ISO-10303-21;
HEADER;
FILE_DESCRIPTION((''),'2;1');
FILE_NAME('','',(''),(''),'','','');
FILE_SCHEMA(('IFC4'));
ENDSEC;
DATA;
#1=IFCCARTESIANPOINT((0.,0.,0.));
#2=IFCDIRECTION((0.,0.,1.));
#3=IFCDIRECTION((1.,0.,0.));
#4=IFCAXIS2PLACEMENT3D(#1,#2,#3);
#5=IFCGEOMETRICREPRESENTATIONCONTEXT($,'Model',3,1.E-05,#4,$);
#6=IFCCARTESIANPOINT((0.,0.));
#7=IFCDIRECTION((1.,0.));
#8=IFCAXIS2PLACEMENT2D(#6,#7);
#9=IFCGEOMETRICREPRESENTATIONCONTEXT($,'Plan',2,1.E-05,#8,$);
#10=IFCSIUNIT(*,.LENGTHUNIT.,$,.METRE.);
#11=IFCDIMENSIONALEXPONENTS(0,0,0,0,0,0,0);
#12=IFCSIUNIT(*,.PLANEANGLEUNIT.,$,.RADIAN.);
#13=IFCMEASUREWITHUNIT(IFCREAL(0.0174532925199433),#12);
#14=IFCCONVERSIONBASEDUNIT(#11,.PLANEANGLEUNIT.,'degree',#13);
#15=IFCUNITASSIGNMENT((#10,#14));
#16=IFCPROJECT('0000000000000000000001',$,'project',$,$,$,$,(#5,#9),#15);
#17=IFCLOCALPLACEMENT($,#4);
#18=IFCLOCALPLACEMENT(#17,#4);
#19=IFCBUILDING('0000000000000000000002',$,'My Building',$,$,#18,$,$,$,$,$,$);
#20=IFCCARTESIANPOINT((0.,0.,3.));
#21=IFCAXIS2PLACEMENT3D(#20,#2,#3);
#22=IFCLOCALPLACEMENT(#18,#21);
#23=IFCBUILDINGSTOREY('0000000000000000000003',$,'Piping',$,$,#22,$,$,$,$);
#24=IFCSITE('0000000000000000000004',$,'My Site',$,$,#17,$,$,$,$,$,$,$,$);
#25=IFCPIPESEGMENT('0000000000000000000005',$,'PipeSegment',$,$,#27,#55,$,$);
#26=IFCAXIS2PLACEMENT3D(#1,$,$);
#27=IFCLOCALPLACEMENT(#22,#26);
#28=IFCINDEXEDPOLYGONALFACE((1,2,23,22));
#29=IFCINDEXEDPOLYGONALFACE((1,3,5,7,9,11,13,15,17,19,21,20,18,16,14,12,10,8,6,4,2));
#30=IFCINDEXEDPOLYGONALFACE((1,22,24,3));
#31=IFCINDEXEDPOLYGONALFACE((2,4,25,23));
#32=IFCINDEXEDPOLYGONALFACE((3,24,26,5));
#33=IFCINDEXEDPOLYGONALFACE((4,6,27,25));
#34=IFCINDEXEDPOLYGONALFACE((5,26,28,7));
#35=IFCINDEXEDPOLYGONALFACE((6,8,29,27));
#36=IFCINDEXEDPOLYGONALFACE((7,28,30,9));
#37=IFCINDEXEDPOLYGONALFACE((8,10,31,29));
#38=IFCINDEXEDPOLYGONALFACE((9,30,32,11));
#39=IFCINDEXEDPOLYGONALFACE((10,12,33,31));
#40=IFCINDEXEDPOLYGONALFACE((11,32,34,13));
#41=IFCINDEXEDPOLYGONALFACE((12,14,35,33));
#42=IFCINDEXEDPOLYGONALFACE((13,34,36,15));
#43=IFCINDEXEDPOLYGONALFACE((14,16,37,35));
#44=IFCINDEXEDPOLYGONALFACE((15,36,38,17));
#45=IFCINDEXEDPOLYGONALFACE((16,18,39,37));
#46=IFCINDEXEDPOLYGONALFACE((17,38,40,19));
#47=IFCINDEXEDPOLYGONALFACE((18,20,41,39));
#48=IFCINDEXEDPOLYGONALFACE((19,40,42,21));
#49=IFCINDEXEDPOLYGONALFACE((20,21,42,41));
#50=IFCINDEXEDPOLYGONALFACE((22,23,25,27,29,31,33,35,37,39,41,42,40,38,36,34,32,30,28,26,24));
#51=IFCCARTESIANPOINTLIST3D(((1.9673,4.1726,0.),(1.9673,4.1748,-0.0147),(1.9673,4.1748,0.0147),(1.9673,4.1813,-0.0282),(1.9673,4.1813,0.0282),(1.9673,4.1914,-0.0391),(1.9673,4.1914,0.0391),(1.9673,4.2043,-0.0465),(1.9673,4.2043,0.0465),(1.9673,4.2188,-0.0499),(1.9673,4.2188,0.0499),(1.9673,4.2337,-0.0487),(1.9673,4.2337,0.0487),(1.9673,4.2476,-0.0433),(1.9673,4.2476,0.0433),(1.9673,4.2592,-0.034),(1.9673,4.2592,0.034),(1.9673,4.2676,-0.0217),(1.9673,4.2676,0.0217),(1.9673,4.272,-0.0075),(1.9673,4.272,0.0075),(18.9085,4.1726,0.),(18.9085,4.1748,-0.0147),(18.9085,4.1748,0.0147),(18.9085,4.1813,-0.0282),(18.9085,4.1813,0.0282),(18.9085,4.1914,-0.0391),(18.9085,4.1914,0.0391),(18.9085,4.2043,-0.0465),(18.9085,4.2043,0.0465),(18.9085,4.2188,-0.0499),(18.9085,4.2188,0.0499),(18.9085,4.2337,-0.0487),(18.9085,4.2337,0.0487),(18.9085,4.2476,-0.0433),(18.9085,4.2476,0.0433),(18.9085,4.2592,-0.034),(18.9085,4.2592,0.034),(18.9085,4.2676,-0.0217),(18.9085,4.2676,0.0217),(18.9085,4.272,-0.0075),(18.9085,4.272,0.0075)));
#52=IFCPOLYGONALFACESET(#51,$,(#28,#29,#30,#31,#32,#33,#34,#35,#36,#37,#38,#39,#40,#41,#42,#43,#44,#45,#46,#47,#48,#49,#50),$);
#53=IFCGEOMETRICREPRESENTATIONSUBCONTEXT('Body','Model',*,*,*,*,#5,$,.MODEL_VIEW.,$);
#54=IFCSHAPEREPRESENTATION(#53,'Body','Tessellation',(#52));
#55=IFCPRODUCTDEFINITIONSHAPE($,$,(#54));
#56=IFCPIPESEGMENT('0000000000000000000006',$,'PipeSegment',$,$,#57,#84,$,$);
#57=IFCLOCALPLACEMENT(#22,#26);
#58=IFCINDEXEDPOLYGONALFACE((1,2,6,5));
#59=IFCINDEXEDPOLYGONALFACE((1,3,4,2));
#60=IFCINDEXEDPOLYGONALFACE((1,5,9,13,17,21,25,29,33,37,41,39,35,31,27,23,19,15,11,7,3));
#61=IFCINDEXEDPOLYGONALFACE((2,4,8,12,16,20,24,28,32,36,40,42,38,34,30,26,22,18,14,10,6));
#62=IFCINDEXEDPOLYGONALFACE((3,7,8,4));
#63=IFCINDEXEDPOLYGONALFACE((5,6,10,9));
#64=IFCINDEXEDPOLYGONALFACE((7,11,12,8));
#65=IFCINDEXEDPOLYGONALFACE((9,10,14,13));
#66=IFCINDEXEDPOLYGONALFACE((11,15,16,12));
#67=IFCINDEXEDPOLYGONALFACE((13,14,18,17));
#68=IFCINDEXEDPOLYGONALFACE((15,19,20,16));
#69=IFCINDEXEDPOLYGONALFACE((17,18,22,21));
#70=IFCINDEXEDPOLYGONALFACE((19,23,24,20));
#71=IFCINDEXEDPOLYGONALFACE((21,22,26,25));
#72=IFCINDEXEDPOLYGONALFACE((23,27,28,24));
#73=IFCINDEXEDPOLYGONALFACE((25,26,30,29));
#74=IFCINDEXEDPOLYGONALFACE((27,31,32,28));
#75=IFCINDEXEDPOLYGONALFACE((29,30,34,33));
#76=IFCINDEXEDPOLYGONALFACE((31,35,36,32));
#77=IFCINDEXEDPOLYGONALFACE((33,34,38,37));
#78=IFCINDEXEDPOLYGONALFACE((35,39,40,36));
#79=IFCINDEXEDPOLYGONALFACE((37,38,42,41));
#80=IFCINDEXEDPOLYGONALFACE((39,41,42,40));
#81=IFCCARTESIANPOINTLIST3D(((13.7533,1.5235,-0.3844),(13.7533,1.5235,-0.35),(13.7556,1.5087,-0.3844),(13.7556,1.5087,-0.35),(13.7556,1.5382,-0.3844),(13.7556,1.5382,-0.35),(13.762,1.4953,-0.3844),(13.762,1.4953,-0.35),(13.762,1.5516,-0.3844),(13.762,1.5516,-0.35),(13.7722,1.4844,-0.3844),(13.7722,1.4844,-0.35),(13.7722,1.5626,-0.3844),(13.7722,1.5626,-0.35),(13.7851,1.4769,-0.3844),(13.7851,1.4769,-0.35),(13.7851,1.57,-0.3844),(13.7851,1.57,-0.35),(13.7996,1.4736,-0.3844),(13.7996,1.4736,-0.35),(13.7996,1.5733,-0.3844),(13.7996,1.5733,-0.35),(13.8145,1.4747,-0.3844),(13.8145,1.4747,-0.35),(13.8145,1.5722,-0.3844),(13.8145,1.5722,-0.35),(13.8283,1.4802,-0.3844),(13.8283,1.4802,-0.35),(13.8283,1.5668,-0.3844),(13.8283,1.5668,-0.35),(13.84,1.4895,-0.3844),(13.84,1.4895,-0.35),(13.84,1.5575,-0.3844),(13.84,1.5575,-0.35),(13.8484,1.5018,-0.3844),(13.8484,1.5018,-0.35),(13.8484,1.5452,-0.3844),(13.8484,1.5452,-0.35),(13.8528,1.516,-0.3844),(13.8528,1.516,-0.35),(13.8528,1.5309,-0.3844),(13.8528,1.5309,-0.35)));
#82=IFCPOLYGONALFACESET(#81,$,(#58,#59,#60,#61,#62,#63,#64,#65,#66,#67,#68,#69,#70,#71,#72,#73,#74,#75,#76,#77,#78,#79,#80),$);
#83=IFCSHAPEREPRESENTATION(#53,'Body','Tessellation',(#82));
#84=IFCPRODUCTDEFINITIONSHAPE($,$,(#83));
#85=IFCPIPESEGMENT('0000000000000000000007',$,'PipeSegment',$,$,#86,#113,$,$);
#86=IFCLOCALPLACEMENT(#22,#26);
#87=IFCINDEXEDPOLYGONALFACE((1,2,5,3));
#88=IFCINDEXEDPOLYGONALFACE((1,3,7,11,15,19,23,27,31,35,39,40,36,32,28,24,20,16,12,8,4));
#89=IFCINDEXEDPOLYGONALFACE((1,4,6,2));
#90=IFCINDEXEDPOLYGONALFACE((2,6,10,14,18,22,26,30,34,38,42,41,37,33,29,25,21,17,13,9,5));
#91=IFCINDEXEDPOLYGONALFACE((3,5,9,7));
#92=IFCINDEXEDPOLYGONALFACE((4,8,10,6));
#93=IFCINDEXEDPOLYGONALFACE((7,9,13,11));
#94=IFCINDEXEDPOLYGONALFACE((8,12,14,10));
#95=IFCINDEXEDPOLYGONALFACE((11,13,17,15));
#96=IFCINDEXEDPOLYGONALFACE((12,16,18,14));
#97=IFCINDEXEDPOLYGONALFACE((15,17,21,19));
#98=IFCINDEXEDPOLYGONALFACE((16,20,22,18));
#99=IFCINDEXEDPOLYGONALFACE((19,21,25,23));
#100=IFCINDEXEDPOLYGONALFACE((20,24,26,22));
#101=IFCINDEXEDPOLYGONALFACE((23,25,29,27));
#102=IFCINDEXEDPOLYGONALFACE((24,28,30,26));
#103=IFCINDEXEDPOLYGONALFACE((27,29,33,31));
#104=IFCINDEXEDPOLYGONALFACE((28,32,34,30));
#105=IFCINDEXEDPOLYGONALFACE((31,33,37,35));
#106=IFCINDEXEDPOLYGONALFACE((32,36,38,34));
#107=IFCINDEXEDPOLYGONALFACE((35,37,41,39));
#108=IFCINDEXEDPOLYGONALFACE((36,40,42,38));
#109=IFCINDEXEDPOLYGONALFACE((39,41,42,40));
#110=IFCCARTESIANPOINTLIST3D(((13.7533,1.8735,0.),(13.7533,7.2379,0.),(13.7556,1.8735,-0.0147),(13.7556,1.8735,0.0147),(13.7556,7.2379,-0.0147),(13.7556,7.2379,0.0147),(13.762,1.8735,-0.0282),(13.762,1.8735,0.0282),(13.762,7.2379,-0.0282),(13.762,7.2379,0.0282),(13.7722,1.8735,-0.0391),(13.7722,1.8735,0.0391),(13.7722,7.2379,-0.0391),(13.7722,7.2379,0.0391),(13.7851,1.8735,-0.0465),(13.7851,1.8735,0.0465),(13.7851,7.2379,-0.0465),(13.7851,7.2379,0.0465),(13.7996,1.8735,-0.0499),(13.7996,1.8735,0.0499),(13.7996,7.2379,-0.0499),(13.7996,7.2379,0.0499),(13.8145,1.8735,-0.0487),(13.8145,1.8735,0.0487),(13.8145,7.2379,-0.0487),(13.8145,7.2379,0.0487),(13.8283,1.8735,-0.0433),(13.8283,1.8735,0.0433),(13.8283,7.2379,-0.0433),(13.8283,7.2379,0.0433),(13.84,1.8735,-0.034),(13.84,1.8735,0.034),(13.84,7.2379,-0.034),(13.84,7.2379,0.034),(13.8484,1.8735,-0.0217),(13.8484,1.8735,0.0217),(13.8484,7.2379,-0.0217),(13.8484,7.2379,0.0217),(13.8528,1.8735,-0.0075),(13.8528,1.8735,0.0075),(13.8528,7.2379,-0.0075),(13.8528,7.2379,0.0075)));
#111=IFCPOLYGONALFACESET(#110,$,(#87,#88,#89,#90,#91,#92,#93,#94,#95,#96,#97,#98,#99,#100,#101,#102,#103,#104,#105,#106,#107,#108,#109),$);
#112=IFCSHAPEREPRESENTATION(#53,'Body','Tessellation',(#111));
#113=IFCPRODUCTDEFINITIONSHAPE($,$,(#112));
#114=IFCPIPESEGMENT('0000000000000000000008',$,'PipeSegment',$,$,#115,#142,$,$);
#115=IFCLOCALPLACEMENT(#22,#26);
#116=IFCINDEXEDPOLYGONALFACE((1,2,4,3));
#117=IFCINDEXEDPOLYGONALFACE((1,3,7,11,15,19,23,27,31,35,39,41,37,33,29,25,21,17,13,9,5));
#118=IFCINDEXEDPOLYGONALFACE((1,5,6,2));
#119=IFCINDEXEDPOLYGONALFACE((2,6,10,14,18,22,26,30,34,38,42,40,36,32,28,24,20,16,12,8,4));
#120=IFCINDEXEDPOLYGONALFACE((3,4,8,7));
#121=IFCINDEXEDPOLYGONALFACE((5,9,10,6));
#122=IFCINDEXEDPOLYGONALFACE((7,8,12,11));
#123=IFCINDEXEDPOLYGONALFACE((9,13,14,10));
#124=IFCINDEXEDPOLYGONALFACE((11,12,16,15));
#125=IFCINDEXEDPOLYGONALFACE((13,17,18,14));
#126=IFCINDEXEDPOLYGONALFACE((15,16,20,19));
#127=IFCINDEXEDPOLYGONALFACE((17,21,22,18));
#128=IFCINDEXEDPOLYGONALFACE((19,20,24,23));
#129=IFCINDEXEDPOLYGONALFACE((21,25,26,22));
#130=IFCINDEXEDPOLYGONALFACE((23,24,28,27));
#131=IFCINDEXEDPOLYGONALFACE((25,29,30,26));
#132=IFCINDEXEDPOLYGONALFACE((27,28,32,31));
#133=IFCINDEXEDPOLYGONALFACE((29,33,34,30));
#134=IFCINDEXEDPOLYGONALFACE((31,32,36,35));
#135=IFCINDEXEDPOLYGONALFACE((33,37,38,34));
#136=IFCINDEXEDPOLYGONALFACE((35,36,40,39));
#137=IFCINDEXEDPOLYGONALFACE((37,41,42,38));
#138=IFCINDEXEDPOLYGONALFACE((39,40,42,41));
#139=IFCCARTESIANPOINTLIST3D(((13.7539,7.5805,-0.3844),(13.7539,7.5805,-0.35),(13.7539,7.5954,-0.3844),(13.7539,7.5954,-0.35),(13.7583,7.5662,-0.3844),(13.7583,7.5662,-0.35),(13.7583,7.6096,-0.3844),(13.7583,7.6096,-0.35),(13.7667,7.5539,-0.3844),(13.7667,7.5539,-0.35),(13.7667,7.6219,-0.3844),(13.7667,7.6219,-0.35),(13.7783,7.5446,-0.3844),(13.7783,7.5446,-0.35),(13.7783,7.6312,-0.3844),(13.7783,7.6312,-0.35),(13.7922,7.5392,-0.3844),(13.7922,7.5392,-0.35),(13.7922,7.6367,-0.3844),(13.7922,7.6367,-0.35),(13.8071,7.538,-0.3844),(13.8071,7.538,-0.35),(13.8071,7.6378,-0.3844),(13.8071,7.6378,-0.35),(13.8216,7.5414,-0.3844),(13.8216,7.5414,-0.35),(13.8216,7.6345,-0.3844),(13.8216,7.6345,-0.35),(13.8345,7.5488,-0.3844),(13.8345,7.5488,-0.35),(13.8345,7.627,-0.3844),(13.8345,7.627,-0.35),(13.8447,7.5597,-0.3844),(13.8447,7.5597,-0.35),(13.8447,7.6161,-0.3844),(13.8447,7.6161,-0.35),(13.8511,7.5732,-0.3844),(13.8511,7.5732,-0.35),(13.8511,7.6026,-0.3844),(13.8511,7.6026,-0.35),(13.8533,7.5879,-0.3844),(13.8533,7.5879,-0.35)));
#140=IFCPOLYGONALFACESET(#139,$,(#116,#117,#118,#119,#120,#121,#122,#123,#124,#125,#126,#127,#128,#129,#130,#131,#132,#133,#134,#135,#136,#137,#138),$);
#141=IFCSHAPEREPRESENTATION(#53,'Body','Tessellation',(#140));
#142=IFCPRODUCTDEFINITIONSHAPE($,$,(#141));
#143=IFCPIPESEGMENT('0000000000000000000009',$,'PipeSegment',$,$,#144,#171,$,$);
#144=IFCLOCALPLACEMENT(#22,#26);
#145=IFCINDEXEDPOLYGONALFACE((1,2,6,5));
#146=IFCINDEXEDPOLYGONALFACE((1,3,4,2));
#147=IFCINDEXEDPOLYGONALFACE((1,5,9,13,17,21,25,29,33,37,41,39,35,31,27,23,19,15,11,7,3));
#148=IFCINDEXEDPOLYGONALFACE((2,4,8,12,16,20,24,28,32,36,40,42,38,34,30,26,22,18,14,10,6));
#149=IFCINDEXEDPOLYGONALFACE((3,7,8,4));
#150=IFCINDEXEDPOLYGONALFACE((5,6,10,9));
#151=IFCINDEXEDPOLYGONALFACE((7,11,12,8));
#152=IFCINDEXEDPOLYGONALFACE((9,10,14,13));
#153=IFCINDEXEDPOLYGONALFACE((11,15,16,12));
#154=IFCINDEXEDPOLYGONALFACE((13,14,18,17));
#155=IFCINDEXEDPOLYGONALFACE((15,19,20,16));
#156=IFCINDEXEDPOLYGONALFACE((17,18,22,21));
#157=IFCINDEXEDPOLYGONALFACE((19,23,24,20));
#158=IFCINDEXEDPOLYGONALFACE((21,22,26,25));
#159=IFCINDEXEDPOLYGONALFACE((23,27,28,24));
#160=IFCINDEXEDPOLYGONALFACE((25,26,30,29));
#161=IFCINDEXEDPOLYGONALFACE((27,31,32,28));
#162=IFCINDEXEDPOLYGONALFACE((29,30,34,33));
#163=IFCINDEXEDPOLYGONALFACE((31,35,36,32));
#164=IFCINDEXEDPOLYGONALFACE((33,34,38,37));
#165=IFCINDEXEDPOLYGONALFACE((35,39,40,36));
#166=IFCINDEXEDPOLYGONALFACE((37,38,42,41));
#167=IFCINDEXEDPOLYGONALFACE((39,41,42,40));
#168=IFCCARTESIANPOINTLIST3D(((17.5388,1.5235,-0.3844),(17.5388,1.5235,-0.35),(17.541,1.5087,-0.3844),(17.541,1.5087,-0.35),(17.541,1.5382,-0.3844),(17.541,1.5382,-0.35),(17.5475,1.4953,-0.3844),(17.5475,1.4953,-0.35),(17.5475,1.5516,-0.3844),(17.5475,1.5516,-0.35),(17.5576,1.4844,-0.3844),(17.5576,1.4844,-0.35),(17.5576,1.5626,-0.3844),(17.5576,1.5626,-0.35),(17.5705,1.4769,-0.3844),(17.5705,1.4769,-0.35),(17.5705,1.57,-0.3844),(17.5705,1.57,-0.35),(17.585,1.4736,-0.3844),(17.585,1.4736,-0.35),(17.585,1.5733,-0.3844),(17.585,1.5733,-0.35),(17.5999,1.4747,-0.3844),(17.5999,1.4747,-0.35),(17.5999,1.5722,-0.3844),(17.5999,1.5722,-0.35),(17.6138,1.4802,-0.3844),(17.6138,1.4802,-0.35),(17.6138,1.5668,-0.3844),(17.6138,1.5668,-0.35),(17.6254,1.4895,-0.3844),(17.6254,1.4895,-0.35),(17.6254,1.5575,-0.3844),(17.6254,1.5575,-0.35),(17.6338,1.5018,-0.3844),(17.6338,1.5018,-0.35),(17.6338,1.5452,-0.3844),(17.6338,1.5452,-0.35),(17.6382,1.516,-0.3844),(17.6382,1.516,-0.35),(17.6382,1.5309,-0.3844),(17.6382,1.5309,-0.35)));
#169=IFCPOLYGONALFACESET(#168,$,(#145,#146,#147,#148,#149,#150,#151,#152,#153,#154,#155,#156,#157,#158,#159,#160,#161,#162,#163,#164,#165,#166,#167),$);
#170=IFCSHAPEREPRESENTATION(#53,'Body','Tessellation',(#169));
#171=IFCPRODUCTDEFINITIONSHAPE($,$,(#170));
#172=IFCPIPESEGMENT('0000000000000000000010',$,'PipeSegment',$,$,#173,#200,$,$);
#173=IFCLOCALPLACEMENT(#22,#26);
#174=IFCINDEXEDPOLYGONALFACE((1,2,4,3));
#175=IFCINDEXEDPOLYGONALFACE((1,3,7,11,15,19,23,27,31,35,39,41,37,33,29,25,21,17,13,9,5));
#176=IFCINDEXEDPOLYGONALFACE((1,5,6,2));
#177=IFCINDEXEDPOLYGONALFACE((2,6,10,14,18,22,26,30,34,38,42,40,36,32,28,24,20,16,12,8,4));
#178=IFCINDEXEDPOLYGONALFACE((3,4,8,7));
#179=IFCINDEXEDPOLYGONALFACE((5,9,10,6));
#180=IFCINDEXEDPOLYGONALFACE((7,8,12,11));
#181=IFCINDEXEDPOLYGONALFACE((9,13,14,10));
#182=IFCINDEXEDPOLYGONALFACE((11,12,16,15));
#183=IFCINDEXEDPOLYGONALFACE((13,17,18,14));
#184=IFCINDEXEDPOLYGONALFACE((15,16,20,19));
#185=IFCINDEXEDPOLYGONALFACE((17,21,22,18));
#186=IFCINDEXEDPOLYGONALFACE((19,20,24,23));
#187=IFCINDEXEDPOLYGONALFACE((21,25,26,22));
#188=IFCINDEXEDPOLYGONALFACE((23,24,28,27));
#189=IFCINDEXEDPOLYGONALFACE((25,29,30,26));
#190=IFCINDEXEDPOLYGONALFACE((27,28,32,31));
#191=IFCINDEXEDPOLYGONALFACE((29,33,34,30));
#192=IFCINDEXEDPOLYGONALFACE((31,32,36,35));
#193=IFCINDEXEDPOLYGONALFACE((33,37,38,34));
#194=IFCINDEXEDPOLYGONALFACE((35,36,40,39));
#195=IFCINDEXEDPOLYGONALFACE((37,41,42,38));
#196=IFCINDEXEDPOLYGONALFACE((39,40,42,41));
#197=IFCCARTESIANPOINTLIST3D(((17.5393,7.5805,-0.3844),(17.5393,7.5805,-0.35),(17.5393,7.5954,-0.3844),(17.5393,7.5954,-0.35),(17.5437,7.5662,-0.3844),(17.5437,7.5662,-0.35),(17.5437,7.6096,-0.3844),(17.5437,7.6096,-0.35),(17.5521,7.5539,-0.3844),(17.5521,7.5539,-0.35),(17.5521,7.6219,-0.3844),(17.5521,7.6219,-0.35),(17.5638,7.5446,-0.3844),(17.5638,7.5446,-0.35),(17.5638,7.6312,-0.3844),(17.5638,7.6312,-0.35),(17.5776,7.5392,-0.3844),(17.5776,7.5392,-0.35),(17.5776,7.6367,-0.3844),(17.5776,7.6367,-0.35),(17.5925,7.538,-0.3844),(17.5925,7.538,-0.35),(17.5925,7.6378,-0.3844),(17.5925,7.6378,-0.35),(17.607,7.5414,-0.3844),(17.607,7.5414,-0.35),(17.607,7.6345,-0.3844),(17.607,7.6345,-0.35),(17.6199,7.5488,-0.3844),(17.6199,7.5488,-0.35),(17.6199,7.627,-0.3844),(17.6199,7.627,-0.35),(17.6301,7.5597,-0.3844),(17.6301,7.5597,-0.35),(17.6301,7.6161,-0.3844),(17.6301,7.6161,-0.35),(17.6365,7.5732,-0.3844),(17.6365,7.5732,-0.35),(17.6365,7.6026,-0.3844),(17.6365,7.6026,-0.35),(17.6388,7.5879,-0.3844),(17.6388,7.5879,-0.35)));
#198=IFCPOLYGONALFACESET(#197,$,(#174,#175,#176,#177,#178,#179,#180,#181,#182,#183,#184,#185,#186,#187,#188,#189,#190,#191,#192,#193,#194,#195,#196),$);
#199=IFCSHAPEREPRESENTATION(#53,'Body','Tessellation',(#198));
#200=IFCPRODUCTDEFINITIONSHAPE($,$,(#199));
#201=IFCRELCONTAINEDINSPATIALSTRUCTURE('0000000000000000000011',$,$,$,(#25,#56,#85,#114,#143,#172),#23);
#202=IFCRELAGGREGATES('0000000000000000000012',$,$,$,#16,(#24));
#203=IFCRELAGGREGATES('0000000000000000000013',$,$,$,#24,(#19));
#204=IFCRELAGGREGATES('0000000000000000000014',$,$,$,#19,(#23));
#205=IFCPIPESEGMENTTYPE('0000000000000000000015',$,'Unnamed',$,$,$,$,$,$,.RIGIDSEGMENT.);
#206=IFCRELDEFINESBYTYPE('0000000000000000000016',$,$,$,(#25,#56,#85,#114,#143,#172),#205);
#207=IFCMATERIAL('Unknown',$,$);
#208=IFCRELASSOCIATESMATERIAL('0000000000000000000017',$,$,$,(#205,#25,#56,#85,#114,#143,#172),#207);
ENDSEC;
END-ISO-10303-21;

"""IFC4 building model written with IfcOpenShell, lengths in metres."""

from ifc_helpers import new_model, entity, si_unit, converted_unit, frame, origin_with_axes, origin_2d_with_axis, place, context, subcontext, project, spatial, circle, extrude, material, material_profile, profile_set, profile_usage, type_object, element, save


model = new_model("IFC4")

# Units and contexts
model_context = context("Model", 3, precision=1e-05, world=origin_with_axes())
plan_context = context("Plan", 2, precision=1e-05, world=origin_2d_with_axis())
body_context = subcontext(model_context, "Body", "Model", "MODEL_VIEW")
ifc_project = project(units=[si_unit("LENGTHUNIT", "METRE"), converted_unit("PLANEANGLEUNIT", "degree", entity("IfcReal", 0.0174532925199433), si_unit("PLANEANGLEUNIT", "RADIAN"), dimensions=[0, 0, 0, 0, 0, 0, 0])], contexts=[model_context, plan_context])

# Site, building, storey
site_placement = place(None, origin_with_axes())
site = spatial("IfcSite", under=ifc_project, at=site_placement, Name="My Site")
building_placement = place(site_placement, origin_with_axes())
building = spatial("IfcBuilding", under=site, at=building_placement, Name="My Building")
storey_placement = place(building_placement, frame((0.0, 0.0, 3.0), z_axis=(0.0, 0.0, 1.0), x_axis=(1.0, 0.0, 0.0)))
storey = spatial("IfcBuildingStorey", under=building, at=storey_placement, Name="Piping")

# Pipe segments
ifc_material = material(Name="Unknown")
ifc_material_profile = material_profile(ifc_material, circle(Radius=0.05))
ifc_profile_set = profile_set([ifc_material_profile])
ifc_profile_usage_1 = profile_usage(ifc_profile_set, cardinal=5)
pipe_segment_type = type_object("IfcPipeSegmentType", Name="Unnamed", PredefinedType="RIGIDSEGMENT", material=ifc_profile_set)
pipe_segment_1_placement = place(storey_placement, frame((18.9085, 4.2226, 0.0), z_axis=(-1.0, 0.0, 0.0), x_axis=(0.0, -1.0, 0.0)))
element("IfcPipeSegment", 1, at=pipe_segment_1_placement, inside=storey, type_object=pipe_segment_type, material=ifc_profile_usage_1, Name="PipeSegment", context=body_context, shape_type="SweptSolid", body=[
    extrude(circle(Radius=0.05), origin_with_axes(), (0.0, 0.0, 1.0), 16.9412),
])
ifc_profile_usage_2 = profile_usage(ifc_profile_set, cardinal=5)
pipe_segment_2_placement = place(storey_placement, frame((13.8033, 1.5235, -0.35), z_axis=(0.0, 0.0, -1.0), x_axis=(-1.0, 0.0, 0.0)))
element("IfcPipeSegment", 2, at=pipe_segment_2_placement, inside=storey, type_object=pipe_segment_type, material=ifc_profile_usage_2, Name="PipeSegment", context=body_context, shape_type="SweptSolid", body=[
    extrude(circle(Radius=0.05), origin_with_axes(), (0.0, 0.0, 1.0), 0.0344),
])
ifc_profile_usage_3 = profile_usage(ifc_profile_set, cardinal=5)
pipe_segment_3_placement = place(storey_placement, frame((13.8033, 1.8735, 0.0), z_axis=(0.0, 1.0, 0.0), x_axis=(-1.0, 0.0, 0.0)))
element("IfcPipeSegment", 3, at=pipe_segment_3_placement, inside=storey, type_object=pipe_segment_type, material=ifc_profile_usage_3, Name="PipeSegment", context=body_context, shape_type="SweptSolid", body=[
    extrude(circle(Radius=0.05), origin_with_axes(), (0.0, 0.0, 1.0), 5.3645),
])
ifc_profile_usage_4 = profile_usage(ifc_profile_set, cardinal=5)
pipe_segment_4_placement = place(storey_placement, frame((13.8033, 7.5879, -0.35), z_axis=(0.0, 0.0, -1.0), x_axis=(1.0, 0.0, 0.0)))
element("IfcPipeSegment", 4, at=pipe_segment_4_placement, inside=storey, type_object=pipe_segment_type, material=ifc_profile_usage_4, Name="PipeSegment", context=body_context, shape_type="SweptSolid", body=[
    extrude(circle(Radius=0.05), origin_with_axes(), (0.0, 0.0, 1.0), 0.0344),
])
ifc_profile_usage_5 = profile_usage(ifc_profile_set, cardinal=5)
pipe_segment_5_placement = place(storey_placement, frame((17.5888, 1.5235, -0.35), z_axis=(0.0, 0.0, -1.0), x_axis=(-1.0, 0.0, 0.0)))
element("IfcPipeSegment", 5, at=pipe_segment_5_placement, inside=storey, type_object=pipe_segment_type, material=ifc_profile_usage_5, Name="PipeSegment", context=body_context, shape_type="SweptSolid", body=[
    extrude(circle(Radius=0.05), origin_with_axes(), (0.0, 0.0, 1.0), 0.0344),
])
ifc_profile_usage_6 = profile_usage(ifc_profile_set, cardinal=5)
pipe_segment_6_placement = place(storey_placement, frame((17.5888, 7.5879, -0.35), z_axis=(0.0, 0.0, -1.0), x_axis=(1.0, 0.0, 0.0)))
element("IfcPipeSegment", 6, at=pipe_segment_6_placement, inside=storey, type_object=pipe_segment_type, material=ifc_profile_usage_6, Name="PipeSegment", context=body_context, shape_type="SweptSolid", body=[
    extrude(circle(Radius=0.05), origin_with_axes(), (0.0, 0.0, 1.0), 0.0344),
])

save(model, "model.ifc")
